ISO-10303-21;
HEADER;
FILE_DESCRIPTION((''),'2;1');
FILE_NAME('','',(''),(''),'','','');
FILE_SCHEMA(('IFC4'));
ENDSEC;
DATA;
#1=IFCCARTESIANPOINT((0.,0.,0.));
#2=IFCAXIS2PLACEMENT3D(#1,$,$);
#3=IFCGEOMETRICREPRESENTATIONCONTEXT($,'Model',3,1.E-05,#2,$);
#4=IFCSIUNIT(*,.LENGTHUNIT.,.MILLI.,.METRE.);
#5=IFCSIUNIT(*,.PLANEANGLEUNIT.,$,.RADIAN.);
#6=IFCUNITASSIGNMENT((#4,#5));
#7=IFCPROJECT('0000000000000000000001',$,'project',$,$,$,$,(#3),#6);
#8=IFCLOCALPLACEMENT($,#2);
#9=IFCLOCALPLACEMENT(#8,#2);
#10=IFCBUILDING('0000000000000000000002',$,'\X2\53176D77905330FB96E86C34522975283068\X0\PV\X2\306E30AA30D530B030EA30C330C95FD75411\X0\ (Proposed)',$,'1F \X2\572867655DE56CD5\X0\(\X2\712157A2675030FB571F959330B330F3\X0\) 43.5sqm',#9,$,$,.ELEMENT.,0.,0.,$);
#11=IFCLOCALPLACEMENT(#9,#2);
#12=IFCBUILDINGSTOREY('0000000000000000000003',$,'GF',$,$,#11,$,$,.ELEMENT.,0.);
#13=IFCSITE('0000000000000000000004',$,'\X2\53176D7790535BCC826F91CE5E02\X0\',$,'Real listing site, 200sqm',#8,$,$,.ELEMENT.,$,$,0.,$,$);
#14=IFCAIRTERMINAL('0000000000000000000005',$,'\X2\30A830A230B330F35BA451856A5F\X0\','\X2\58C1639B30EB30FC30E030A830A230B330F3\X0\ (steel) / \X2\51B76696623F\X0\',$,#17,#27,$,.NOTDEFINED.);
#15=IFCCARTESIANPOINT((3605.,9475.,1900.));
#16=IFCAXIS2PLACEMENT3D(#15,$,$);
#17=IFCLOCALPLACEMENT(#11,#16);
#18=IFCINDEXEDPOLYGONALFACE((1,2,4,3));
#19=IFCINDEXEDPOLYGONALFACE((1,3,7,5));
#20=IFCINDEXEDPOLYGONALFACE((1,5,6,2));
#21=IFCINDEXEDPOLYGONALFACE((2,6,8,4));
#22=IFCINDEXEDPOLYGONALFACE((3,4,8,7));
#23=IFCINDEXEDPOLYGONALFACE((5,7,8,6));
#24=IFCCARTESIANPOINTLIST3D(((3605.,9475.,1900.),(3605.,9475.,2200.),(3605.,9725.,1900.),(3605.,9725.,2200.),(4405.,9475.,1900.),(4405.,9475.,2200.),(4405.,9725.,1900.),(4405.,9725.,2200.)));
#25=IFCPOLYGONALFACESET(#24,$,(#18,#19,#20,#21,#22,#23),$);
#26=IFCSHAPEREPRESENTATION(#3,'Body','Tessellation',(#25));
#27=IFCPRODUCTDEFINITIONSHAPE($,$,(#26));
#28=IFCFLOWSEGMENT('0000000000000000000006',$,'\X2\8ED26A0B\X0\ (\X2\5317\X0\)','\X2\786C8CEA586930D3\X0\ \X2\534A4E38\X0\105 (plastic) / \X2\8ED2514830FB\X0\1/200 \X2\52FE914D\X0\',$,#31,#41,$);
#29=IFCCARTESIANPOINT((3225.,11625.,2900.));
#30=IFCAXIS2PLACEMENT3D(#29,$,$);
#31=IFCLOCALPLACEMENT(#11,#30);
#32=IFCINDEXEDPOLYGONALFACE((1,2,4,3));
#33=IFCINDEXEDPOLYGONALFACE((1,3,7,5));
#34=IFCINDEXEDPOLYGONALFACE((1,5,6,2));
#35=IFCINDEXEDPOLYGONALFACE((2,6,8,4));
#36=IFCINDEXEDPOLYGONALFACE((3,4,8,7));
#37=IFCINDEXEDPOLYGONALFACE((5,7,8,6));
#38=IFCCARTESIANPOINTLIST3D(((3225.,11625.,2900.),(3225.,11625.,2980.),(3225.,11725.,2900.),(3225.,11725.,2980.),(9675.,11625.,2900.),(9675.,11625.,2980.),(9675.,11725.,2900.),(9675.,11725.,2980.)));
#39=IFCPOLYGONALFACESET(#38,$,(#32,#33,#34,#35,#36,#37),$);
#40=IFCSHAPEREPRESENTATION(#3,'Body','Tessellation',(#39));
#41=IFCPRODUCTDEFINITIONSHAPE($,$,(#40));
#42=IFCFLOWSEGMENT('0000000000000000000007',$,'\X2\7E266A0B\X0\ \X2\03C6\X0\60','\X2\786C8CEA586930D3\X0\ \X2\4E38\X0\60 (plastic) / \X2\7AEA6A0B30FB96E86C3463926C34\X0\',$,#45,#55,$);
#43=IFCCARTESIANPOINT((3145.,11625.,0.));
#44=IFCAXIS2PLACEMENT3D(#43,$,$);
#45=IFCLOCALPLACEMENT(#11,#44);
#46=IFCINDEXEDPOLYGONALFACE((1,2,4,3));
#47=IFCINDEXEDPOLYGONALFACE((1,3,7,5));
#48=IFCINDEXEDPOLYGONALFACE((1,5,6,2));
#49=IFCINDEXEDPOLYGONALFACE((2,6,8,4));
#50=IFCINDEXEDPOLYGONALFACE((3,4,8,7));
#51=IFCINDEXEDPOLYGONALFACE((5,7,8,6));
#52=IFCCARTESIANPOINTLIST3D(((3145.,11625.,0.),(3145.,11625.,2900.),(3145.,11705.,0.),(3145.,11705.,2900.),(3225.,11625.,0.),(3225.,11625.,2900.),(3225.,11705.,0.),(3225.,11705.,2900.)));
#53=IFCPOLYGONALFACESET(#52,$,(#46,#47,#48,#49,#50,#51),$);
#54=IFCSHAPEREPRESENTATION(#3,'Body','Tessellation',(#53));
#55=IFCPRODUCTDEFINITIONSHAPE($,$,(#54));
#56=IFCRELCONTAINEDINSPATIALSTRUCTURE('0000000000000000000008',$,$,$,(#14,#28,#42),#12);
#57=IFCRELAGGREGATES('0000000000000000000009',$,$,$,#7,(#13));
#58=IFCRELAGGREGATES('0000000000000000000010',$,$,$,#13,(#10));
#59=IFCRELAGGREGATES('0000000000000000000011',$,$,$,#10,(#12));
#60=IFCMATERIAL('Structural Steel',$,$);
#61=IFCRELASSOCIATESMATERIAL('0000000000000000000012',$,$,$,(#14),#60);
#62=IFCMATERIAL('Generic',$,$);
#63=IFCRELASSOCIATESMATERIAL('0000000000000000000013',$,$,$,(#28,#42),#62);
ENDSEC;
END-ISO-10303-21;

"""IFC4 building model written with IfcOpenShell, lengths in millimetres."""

from ifc_helpers import new_model, si_unit, frame, frame_2d, origin, place, context, project, spatial, rectangle, extrude, material, element, save


model = new_model("IFC4")

# Units and contexts
model_context = context("Model", 3, precision=1e-05, world=origin())
ifc_project = project(units=[si_unit("LENGTHUNIT", "METRE", prefix="MILLI"), si_unit("PLANEANGLEUNIT", "RADIAN")], contexts=[model_context])

# Site, building, storey
site_placement = place(None, origin())
site = spatial("IfcSite", under=ifc_project, at=site_placement, Name="北海道富良野市", ObjectType="Real listing site, 200sqm", CompositionType="ELEMENT", RefElevation=0.0)
building_placement = place(site_placement, origin())
building = spatial("IfcBuilding", under=site, at=building_placement, Name="北海道・雨水利用とPVのオフグリッド志向 (Proposed)", ObjectType="1F 在来工法(無垢材・土間コン) 43.5sqm", CompositionType="ELEMENT", ElevationOfRefHeight=0.0, ElevationOfTerrain=0.0)
storey_placement = place(building_placement, origin())
storey = spatial("IfcBuildingStorey", under=building, at=storey_placement, Name="GF", CompositionType="ELEMENT", Elevation=0.0)

# Shared definitions
ifc_material_1 = material(Name="Generic")

# Shared definitions
ifc_material_2 = material(Name="Structural Steel")

# Air terminal
air_terminal_placement = place(storey_placement, frame((3605.0, 9475.0, 1900.0)))
element("IfcAirTerminal", 1, at=air_terminal_placement, inside=storey, material=ifc_material_2, Name="エアコン室内機", Description="壁掛ルームエアコン (steel) / 冷暖房", PredefinedType="NOTDEFINED", context=model_context, shape_type="SweptSolid", body=[
    extrude(rectangle(XDim=800.0, YDim=250.0, at=frame_2d((400.0, 125.0))), frame((3605.0, 9475.0, 1900.0)), (0.0, 0.0, 1.0), 300.0),
])

# Flow segments
flow_segment_1_placement = place(storey_placement, frame((3225.0, 11625.0, 2900.0)))
element("IfcFlowSegment", 2, at=flow_segment_1_placement, inside=storey, material=ifc_material_1, Name="軒樋 (北)", Description="硬質塩ビ 半丸105 (plastic) / 軒先・1/200 勾配", context=model_context, shape_type="SweptSolid", body=[
    extrude(rectangle(XDim=6450.0, YDim=100.0, at=frame_2d((3225.0, 50.0))), frame((3225.0, 11625.0, 2900.0)), (0.0, 0.0, 1.0), 80.0),
])
flow_segment_2_placement = place(storey_placement, frame((3145.0, 11625.0, 0.0)))
element("IfcFlowSegment", 3, at=flow_segment_2_placement, inside=storey, material=ifc_material_1, Name="縦樋 φ60", Description="硬質塩ビ 丸60 (plastic) / 竪樋・雨水排水", context=model_context, shape_type="SweptSolid", body=[
    extrude(rectangle(XDim=80.0, YDim=80.0, at=frame_2d((40.0, 40.0))), frame((3145.0, 11625.0, 0.0)), (0.0, 0.0, 1.0), 2900.0),
])

save(model, "model.ifc")
